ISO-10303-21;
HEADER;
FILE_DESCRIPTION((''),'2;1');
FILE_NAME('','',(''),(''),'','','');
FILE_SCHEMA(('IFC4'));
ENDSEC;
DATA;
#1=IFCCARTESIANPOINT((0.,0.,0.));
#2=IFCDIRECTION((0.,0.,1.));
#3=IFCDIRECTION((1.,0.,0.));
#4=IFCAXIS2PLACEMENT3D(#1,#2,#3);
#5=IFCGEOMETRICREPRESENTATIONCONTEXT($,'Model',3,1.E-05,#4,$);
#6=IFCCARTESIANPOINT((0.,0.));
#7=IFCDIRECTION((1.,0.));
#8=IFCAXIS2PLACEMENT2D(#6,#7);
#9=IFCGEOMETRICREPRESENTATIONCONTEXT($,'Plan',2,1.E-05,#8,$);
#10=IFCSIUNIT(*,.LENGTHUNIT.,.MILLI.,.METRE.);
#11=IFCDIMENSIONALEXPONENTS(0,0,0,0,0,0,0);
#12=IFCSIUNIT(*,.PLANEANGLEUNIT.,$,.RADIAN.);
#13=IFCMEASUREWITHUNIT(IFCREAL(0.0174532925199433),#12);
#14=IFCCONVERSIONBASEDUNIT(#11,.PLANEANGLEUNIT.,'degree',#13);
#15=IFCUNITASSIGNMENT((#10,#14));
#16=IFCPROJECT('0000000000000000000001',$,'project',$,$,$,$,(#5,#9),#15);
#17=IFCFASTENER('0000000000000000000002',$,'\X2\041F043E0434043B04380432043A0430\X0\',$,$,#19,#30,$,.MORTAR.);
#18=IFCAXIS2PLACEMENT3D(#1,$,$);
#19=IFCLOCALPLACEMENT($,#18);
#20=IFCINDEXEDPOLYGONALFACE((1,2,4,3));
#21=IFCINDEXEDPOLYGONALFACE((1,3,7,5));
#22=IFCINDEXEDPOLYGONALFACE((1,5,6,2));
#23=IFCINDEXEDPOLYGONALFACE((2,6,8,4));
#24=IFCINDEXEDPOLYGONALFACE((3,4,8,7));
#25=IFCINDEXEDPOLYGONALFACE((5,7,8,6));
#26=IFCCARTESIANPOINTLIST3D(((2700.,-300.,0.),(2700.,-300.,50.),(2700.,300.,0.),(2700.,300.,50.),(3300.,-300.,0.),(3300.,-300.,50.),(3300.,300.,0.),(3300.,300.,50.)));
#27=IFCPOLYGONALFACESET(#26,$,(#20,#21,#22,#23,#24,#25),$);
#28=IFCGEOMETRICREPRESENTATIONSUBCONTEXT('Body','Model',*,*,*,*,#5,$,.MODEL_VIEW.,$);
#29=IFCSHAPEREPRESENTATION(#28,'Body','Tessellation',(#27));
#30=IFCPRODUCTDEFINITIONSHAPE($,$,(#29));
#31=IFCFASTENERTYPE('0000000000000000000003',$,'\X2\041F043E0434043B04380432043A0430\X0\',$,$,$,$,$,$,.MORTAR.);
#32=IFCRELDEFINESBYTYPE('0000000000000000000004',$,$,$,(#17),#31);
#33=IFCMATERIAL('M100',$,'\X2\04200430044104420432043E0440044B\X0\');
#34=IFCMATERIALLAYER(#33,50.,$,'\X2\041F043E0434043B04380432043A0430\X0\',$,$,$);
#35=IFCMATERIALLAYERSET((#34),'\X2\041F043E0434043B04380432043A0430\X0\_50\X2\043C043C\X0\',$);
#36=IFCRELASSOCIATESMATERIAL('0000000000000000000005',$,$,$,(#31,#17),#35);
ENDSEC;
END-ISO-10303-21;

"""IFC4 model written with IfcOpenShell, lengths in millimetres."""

from ifc_helpers import new_model, entity, si_unit, converted_unit, frame, origin_with_axes, origin_2d_with_axis, place, context, subcontext, project, line, indexed_curve, outline, extrude, material, layer, layer_set, layer_usage, type_object, element, save


model = new_model("IFC4")

# Units and contexts
model_context = context("Model", 3, precision=1e-05, world=origin_with_axes())
plan_context = context("Plan", 2, precision=1e-05, world=origin_2d_with_axis())
body_context = subcontext(model_context, "Body", "Model", "MODEL_VIEW")
ifc_project = project(units=[si_unit("LENGTHUNIT", "METRE", prefix="MILLI"), converted_unit("PLANEANGLEUNIT", "degree", entity("IfcReal", 0.0174532925199433), si_unit("PLANEANGLEUNIT", "RADIAN"), dimensions=[0, 0, 0, 0, 0, 0, 0])], contexts=[model_context, plan_context])

# Fastener
ifc_material = material(Name="M100", Category="Растворы")
ifc_layer = layer(ifc_material, 50.0, Name="Подливка")
ifc_layer_set = layer_set([ifc_layer], Name="Подливка_50мм")
ifc_layer_usage = layer_usage(ifc_layer_set, "AXIS3", "POSITIVE", 0.0)
fastener_type = type_object("IfcFastenerType", Name="Подливка", PredefinedType="MORTAR", material=ifc_layer_set)
fastener_placement = place(None, frame((3000.0, 0.0, 0.0), z_axis=(0.0, 0.0, 1.0), x_axis=(1.0, 0.0, 0.0)))
element("IfcFastener", 1, at=fastener_placement, type_object=fastener_type, material=ifc_layer_usage, Name="Подливка", PredefinedType="MORTAR", context=body_context, shape_type="SweptSolid", body=[
    extrude(outline(indexed_curve([(-300.0, -300.0), (300.0, -300.0), (300.0, 300.0), (-300.0, 300.0)], segments=[line(3, 2), line(2, 1), line(1, 4), line(4, 3)], self_intersect=False)), None, (0.0, 0.0, 1.0), 50.0),
])

save(model, "model.ifc")
